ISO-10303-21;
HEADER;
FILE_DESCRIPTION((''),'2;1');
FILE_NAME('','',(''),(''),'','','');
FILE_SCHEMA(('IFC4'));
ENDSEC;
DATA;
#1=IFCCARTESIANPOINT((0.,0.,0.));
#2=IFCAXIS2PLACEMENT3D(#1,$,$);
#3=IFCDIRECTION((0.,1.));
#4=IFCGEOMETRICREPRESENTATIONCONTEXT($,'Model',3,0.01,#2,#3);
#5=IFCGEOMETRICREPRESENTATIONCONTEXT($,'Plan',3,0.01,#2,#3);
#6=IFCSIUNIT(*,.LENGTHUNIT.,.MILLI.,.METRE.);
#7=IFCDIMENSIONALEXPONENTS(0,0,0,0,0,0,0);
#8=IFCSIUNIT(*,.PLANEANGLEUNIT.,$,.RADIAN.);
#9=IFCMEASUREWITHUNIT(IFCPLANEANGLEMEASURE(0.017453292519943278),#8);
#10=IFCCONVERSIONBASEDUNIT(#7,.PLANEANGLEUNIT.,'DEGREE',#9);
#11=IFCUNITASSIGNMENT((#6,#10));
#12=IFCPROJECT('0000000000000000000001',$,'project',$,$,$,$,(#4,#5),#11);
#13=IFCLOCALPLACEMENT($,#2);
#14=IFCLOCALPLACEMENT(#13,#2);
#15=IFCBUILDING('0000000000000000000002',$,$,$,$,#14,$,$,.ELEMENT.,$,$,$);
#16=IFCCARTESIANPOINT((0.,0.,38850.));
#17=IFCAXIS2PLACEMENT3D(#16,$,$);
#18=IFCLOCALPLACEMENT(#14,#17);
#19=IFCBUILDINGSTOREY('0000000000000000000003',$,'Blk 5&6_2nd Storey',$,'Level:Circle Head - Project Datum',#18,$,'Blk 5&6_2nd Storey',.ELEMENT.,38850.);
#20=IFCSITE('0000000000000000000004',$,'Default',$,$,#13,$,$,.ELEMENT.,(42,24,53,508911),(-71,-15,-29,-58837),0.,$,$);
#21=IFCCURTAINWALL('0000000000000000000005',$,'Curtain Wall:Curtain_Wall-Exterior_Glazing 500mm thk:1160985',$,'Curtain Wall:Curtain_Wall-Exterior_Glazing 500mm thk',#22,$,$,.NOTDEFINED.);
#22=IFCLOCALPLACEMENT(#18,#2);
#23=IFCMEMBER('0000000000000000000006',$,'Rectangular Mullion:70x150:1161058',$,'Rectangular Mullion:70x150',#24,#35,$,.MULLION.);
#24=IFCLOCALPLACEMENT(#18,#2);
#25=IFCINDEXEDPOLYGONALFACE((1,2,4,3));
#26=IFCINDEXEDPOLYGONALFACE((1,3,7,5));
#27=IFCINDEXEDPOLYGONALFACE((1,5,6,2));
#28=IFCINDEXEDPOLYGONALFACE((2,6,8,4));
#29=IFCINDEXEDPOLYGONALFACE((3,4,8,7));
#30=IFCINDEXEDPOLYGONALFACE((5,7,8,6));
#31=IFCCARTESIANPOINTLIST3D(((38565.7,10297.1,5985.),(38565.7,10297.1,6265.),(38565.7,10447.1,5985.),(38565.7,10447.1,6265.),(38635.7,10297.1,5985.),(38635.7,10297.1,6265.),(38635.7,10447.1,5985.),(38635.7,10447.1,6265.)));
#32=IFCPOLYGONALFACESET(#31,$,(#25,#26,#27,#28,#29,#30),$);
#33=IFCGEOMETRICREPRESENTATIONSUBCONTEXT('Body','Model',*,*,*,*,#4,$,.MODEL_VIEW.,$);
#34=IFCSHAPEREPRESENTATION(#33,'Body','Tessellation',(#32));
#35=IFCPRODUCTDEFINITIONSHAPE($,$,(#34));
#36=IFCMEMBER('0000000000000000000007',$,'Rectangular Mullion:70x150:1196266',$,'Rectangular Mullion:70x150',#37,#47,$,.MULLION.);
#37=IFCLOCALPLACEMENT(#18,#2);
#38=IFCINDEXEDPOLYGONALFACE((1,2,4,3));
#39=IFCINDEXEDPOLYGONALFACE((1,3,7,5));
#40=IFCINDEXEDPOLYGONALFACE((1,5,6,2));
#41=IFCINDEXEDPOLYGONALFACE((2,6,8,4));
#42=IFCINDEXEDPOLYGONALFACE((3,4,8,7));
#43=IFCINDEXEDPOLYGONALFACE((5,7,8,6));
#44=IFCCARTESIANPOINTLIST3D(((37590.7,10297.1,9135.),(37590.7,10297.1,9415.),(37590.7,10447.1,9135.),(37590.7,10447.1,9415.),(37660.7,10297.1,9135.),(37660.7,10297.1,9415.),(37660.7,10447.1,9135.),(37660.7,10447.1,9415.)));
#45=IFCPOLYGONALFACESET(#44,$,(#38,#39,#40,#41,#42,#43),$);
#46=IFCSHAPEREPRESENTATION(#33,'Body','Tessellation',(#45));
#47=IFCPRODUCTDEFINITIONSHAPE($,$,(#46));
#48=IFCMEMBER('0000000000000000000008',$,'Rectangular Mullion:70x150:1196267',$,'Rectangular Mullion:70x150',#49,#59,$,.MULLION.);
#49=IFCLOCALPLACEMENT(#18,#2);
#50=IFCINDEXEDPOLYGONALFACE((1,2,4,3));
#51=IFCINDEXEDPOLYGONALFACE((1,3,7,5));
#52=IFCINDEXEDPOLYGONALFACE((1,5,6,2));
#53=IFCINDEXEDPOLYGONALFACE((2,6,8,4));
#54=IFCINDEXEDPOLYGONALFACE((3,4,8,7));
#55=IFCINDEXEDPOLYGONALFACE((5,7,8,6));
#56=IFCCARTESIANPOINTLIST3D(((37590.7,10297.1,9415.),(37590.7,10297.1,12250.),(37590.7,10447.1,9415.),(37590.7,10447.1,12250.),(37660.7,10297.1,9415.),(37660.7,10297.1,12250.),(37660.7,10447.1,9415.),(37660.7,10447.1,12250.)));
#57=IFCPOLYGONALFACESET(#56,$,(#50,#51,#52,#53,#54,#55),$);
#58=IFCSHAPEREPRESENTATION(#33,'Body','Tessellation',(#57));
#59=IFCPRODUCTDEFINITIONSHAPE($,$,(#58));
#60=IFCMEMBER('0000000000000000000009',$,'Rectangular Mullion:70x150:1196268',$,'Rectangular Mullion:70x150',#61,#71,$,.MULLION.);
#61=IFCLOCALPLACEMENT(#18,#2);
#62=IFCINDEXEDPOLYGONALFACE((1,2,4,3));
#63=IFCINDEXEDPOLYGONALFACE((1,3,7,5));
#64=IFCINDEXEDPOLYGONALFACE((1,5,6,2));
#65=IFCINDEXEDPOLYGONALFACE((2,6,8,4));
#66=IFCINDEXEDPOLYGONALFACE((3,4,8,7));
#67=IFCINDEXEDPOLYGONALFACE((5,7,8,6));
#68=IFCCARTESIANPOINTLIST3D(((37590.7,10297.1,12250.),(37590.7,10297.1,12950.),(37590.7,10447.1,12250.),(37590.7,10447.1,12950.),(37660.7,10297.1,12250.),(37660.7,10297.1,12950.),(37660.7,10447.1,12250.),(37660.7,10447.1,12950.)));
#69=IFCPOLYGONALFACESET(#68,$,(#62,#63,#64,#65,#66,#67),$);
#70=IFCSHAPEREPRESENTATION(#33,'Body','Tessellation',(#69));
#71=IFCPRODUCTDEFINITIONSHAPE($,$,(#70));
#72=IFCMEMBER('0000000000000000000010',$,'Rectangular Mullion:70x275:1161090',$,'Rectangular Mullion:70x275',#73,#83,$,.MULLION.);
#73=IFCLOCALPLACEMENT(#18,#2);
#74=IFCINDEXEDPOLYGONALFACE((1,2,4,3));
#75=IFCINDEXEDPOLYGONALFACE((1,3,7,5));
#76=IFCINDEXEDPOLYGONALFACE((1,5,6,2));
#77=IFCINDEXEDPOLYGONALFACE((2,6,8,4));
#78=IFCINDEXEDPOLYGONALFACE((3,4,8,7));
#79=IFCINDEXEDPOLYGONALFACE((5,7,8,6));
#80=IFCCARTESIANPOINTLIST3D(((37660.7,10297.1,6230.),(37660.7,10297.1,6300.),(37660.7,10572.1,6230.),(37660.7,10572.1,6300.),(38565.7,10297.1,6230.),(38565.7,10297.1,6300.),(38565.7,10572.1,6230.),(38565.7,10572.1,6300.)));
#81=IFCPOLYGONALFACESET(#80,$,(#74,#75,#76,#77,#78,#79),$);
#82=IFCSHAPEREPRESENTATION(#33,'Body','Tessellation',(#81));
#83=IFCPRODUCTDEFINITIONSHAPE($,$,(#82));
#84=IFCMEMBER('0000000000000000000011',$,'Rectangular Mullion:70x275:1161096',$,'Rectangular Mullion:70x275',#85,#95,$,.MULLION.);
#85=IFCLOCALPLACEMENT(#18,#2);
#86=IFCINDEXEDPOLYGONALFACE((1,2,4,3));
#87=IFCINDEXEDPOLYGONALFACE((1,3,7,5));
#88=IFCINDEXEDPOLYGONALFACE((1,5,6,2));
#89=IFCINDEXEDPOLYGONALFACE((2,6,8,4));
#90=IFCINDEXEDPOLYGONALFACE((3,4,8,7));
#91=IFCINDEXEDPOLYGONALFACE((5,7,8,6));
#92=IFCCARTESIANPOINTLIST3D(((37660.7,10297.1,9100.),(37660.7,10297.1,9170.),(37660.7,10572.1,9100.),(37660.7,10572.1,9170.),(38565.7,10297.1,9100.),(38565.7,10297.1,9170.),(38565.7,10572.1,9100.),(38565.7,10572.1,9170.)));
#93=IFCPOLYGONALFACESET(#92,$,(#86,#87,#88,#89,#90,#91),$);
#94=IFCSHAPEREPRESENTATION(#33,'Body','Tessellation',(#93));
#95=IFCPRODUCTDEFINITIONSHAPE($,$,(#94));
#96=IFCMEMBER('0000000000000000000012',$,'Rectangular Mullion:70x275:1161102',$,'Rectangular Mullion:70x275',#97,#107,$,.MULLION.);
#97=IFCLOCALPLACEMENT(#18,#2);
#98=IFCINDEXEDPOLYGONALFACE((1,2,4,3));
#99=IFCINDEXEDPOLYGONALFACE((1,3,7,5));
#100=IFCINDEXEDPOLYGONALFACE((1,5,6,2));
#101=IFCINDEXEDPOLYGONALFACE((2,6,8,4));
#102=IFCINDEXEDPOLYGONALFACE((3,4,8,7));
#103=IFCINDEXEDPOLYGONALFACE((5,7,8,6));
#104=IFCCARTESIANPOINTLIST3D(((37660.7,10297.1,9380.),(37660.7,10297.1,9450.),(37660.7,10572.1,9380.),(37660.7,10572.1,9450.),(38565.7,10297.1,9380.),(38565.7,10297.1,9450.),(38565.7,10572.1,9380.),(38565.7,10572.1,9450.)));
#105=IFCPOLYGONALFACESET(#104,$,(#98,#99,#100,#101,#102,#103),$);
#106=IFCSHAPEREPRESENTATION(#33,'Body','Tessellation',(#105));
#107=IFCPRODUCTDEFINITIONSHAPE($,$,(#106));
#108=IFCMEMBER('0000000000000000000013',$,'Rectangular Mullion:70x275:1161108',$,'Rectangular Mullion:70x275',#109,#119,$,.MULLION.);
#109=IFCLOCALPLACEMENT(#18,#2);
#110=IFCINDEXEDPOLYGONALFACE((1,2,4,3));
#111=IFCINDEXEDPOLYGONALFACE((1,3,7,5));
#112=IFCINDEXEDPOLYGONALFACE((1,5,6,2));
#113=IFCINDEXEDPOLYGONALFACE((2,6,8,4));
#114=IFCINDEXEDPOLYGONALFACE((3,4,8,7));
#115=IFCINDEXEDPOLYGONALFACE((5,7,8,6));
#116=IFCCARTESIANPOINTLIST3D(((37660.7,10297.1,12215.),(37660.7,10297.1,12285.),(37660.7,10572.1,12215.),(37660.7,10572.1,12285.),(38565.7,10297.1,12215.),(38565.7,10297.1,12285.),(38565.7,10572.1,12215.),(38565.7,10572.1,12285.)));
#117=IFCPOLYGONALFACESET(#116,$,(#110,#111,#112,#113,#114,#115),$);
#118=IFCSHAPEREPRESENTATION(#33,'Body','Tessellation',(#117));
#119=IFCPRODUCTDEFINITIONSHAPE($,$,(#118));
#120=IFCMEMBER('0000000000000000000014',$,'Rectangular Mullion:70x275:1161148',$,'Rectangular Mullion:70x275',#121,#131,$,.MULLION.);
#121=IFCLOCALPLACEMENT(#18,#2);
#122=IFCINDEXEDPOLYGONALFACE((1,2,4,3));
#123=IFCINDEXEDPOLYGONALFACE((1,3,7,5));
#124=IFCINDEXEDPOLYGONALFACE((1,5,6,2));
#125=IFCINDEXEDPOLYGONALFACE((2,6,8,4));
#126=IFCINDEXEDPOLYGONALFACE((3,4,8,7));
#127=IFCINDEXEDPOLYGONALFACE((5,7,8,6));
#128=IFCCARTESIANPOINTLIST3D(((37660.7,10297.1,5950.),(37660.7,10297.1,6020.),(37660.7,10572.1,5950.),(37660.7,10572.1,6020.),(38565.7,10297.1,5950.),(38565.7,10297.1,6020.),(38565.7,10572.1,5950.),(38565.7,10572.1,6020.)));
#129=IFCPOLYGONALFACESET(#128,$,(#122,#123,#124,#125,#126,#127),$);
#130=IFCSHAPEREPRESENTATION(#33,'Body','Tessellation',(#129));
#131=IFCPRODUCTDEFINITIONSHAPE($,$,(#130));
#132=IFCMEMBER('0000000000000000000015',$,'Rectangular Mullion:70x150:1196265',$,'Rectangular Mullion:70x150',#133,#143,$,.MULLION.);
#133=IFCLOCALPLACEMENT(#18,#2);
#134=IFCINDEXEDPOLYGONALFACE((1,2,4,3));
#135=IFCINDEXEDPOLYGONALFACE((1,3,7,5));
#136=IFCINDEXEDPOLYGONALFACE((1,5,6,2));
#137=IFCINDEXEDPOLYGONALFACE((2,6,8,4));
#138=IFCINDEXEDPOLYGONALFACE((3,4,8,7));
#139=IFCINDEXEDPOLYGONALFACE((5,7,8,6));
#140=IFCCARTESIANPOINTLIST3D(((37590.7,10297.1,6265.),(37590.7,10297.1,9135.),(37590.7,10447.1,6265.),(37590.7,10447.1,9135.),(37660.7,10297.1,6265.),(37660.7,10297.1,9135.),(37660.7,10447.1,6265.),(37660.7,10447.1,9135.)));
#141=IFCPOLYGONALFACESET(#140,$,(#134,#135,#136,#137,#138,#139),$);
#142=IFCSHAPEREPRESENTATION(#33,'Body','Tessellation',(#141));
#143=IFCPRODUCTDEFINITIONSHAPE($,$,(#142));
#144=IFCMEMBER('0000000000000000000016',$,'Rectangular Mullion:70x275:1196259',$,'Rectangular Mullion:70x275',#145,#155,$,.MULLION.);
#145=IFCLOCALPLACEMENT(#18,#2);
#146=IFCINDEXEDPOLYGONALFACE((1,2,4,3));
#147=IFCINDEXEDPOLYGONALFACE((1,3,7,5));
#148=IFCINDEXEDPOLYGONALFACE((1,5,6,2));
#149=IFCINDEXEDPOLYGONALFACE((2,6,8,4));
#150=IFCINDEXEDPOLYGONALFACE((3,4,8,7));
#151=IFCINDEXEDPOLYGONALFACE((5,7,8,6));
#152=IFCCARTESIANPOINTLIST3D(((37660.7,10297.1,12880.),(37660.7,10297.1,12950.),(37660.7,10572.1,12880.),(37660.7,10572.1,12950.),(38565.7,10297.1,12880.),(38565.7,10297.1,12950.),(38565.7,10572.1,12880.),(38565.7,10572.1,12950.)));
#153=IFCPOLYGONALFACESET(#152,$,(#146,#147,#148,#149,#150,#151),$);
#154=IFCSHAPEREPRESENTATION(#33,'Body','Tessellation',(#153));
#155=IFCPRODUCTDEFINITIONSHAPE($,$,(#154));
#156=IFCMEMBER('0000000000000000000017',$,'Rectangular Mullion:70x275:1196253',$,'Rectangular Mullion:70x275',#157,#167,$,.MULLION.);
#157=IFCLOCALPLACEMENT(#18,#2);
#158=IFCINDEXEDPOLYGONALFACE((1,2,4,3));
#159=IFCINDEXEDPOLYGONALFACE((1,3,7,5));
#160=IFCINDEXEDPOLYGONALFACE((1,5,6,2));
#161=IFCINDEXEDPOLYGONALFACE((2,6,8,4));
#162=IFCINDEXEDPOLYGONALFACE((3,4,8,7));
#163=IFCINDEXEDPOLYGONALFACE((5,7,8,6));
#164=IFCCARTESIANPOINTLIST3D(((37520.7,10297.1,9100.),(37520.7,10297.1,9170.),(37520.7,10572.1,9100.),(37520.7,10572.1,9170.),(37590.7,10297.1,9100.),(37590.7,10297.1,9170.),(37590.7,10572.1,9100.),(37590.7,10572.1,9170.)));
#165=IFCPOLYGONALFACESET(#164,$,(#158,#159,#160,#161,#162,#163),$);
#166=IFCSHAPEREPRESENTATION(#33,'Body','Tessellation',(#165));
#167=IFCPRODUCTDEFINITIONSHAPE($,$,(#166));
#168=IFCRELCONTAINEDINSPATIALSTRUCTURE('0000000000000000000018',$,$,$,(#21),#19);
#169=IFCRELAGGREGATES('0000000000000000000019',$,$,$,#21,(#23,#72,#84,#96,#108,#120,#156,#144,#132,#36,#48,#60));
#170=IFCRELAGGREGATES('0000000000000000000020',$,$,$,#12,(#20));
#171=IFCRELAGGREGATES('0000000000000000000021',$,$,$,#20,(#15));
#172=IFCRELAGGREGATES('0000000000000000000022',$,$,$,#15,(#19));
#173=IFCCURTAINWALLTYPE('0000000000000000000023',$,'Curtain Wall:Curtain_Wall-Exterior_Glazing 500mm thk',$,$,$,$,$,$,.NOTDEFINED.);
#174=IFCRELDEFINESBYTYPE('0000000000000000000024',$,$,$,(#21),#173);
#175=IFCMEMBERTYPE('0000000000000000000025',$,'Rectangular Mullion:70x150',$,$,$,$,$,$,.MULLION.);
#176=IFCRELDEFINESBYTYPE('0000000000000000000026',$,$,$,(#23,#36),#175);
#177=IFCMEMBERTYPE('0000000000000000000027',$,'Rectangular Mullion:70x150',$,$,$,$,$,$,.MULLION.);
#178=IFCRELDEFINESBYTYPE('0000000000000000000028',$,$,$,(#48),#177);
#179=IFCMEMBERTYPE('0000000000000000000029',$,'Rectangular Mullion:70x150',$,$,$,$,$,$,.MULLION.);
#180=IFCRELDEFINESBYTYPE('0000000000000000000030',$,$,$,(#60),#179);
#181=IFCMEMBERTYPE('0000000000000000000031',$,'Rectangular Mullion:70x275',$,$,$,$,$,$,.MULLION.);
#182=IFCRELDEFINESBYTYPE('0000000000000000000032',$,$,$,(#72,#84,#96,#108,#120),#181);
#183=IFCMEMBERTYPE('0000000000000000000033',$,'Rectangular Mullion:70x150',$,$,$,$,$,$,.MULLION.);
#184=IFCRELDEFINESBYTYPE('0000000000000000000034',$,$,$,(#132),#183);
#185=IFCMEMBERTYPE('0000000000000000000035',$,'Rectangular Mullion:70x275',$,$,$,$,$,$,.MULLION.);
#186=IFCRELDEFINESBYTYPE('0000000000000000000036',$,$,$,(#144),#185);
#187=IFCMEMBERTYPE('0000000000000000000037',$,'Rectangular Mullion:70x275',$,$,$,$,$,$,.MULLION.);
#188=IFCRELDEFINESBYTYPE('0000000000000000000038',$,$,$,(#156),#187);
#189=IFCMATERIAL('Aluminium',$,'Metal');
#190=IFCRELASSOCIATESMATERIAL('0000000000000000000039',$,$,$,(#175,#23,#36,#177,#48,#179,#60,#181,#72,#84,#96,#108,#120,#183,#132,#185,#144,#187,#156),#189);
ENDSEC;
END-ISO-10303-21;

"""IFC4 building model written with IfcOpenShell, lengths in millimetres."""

from ifc_helpers import new_model, entity, si_unit, converted_unit, direction, frame, origin, place, context, subcontext, project, spatial, indexed_curve, outline, extrude, source, transform, mapped, material, type_object, type_shapes, element, aggregate, save


model = new_model("IFC4")

# Units and contexts
model_context = context("Model", 3, precision=0.01, world=origin(), true_north=direction((0.0, 1.0)))
plan_context = context("Plan", 3, precision=0.01, world=origin(), true_north=direction((0.0, 1.0)))
body_context = subcontext(model_context, "Body", "Model", "MODEL_VIEW")
ifc_project = project(units=[si_unit("LENGTHUNIT", "METRE", prefix="MILLI"), converted_unit("PLANEANGLEUNIT", "DEGREE", entity("IfcPlaneAngleMeasure", 0.017453292519943278), si_unit("PLANEANGLEUNIT", "RADIAN"), dimensions=[0, 0, 0, 0, 0, 0, 0])], contexts=[model_context, plan_context])

# Site, building, storey
site_placement = place(None, origin())
site = spatial("IfcSite", under=ifc_project, at=site_placement, Name="Default", CompositionType="ELEMENT", RefLatitude=(42, 24, 53, 508911), RefLongitude=(-71, -15, -29, -58837), RefElevation=0.0)
building_placement = place(site_placement, origin())
building = spatial("IfcBuilding", under=site, at=building_placement, CompositionType="ELEMENT")
storey_placement = place(building_placement, frame((0.0, 0.0, 38850.0)))
storey = spatial("IfcBuildingStorey", under=building, at=storey_placement, Name="Blk 5&6_2nd Storey", ObjectType="Level:Circle Head - Project Datum", LongName="Blk 5&6_2nd Storey", CompositionType="ELEMENT", Elevation=38850.0)

# Curtain wall, members
curtain_wall_type = type_object("IfcCurtainWallType", Name="Curtain Wall:Curtain_Wall-Exterior_Glazing 500mm thk", PredefinedType="NOTDEFINED")
curtain_wall_placement = place(storey_placement, frame((0.0, 0.0, -38850.0)))
curtain_wall = element("IfcCurtainWall", 1, at=curtain_wall_placement, inside=storey, type_object=curtain_wall_type, Name="Curtain Wall:Curtain_Wall-Exterior_Glazing 500mm thk:1160985", ObjectType="Curtain Wall:Curtain_Wall-Exterior_Glazing 500mm thk", PredefinedType="NOTDEFINED")
ifc_material_1 = material(Name="Aluminium", Category="Metal")
member_type_1 = type_object("IfcMemberType", Name="Rectangular Mullion:70x150", PredefinedType="MULLION", material=ifc_material_1)
shared_shape_1 = source(origin(), body_context, "Body", "SweptSolid", [
    extrude(outline(indexed_curve([(-35.0, -75.0), (35.0, -75.0), (35.0, 75.0), (-35.0, 75.0), (-35.0, -75.0)], self_intersect=False)), frame((0.0, -200.0, -280.0), z_axis=(0.0, 0.0, 1.0), x_axis=(-1.0, 0.0, 0.0)), (0.0, 0.0, 1.0), 280.0),
])
type_shapes(member_type_1, [shared_shape_1])
member_1_placement = place(curtain_wall_placement, frame((38600.7, 10572.1, 44835.0), z_axis=(0.0, 0.0, -1.0), x_axis=(-1.0, 0.0, 0.0)))
member_1 = element("IfcMember", 2, at=member_1_placement, type_object=member_type_1, material=ifc_material_1, Name="Rectangular Mullion:70x150:1161058", ObjectType="Rectangular Mullion:70x150", PredefinedType="MULLION", context=body_context, shape_type="MappedRepresentation", body=[
    mapped(shared_shape_1, transform((0.0, 0.0, 0.0), scale=1.0)),
])
member_2_placement = place(curtain_wall_placement, frame((37625.7, 10572.1, 47985.0), z_axis=(0.0, 0.0, -1.0), x_axis=(-1.0, 0.0, 0.0)))
member_2 = element("IfcMember", 3, at=member_2_placement, type_object=member_type_1, material=ifc_material_1, Name="Rectangular Mullion:70x150:1196266", ObjectType="Rectangular Mullion:70x150", PredefinedType="MULLION", context=body_context, shape_type="MappedRepresentation", body=[
    mapped(shared_shape_1, transform((0.0, 0.0, 0.0), scale=1.0)),
])
member_type_2 = type_object("IfcMemberType", Name="Rectangular Mullion:70x150", PredefinedType="MULLION", material=ifc_material_1)
shared_shape_2 = source(origin(), body_context, "Body", "SweptSolid", [
    extrude(outline(indexed_curve([(-35.0, -75.0), (35.0, -75.0), (35.0, 75.0), (-35.0, 75.0), (-35.0, -75.0)], self_intersect=False)), frame((0.0, -200.0, -2835.0), z_axis=(0.0, 0.0, 1.0), x_axis=(-1.0, 0.0, 0.0)), (0.0, 0.0, 1.0), 2835.0),
])
type_shapes(member_type_2, [shared_shape_2])
member_3_placement = place(curtain_wall_placement, frame((37625.7, 10572.1, 48265.0), z_axis=(0.0, 0.0, -1.0), x_axis=(-1.0, 0.0, 0.0)))
member_3 = element("IfcMember", 4, at=member_3_placement, type_object=member_type_2, material=ifc_material_1, Name="Rectangular Mullion:70x150:1196267", ObjectType="Rectangular Mullion:70x150", PredefinedType="MULLION", context=body_context, shape_type="MappedRepresentation", body=[
    mapped(shared_shape_2, transform((0.0, 0.0, 0.0), scale=1.0)),
])
member_type_3 = type_object("IfcMemberType", Name="Rectangular Mullion:70x150", PredefinedType="MULLION", material=ifc_material_1)
shared_shape_3 = source(origin(), body_context, "Body", "SweptSolid", [
    extrude(outline(indexed_curve([(-35.0, -75.0), (35.0, -75.0), (35.0, 75.0), (-35.0, 75.0), (-35.0, -75.0)], self_intersect=False)), frame((0.0, -200.0, -700.0), z_axis=(0.0, 0.0, 1.0), x_axis=(-1.0, 0.0, 0.0)), (0.0, 0.0, 1.0), 700.0),
])
type_shapes(member_type_3, [shared_shape_3])
member_4_placement = place(curtain_wall_placement, frame((37625.7, 10572.1, 51100.0), z_axis=(0.0, 0.0, -1.0), x_axis=(-1.0, 0.0, 0.0)))
member_4 = element("IfcMember", 5, at=member_4_placement, type_object=member_type_3, material=ifc_material_1, Name="Rectangular Mullion:70x150:1196268", ObjectType="Rectangular Mullion:70x150", PredefinedType="MULLION", context=body_context, shape_type="MappedRepresentation", body=[
    mapped(shared_shape_3, transform((0.0, 0.0, 0.0), scale=1.0)),
])
member_type_4 = type_object("IfcMemberType", Name="Rectangular Mullion:70x275", PredefinedType="MULLION", material=ifc_material_1)
shared_shape_4 = source(origin(), body_context, "Body", "SweptSolid", [
    extrude(outline(indexed_curve([(-35.0, -137.5), (35.0, -137.5), (35.0, 137.5), (-35.0, 137.5), (-35.0, -137.5)], self_intersect=False)), frame((0.0, -137.5, -905.0), z_axis=(0.0, 0.0, 1.0), x_axis=(-1.0, 0.0, 0.0)), (0.0, 0.0, 1.0), 905.0),
])
type_shapes(member_type_4, [shared_shape_4])
member_5_placement = place(curtain_wall_placement, frame((37660.7, 10572.1, 45115.0), z_axis=(-1.0, 0.0, 0.0), x_axis=(0.0, 0.0, 1.0)))
member_5 = element("IfcMember", 6, at=member_5_placement, type_object=member_type_4, material=ifc_material_1, Name="Rectangular Mullion:70x275:1161090", ObjectType="Rectangular Mullion:70x275", PredefinedType="MULLION", context=body_context, shape_type="MappedRepresentation", body=[
    mapped(shared_shape_4, transform((0.0, 0.0, 0.0), scale=1.0)),
])
member_6_placement = place(curtain_wall_placement, frame((37660.7, 10572.1, 47985.0), z_axis=(-1.0, 0.0, 0.0), x_axis=(0.0, 0.0, 1.0)))
member_6 = element("IfcMember", 7, at=member_6_placement, type_object=member_type_4, material=ifc_material_1, Name="Rectangular Mullion:70x275:1161096", ObjectType="Rectangular Mullion:70x275", PredefinedType="MULLION", context=body_context, shape_type="MappedRepresentation", body=[
    mapped(shared_shape_4, transform((0.0, 0.0, 0.0), scale=1.0)),
])
member_7_placement = place(curtain_wall_placement, frame((37660.7, 10572.1, 48265.0), z_axis=(-1.0, 0.0, 0.0), x_axis=(0.0, 0.0, 1.0)))
member_7 = element("IfcMember", 8, at=member_7_placement, type_object=member_type_4, material=ifc_material_1, Name="Rectangular Mullion:70x275:1161102", ObjectType="Rectangular Mullion:70x275", PredefinedType="MULLION", context=body_context, shape_type="MappedRepresentation", body=[
    mapped(shared_shape_4, transform((0.0, 0.0, 0.0), scale=1.0)),
])
member_8_placement = place(curtain_wall_placement, frame((37660.7, 10572.1, 51100.0), z_axis=(-1.0, 0.0, 0.0), x_axis=(0.0, 0.0, 1.0)))
member_8 = element("IfcMember", 9, at=member_8_placement, type_object=member_type_4, material=ifc_material_1, Name="Rectangular Mullion:70x275:1161108", ObjectType="Rectangular Mullion:70x275", PredefinedType="MULLION", context=body_context, shape_type="MappedRepresentation", body=[
    mapped(shared_shape_4, transform((0.0, 0.0, 0.0), scale=1.0)),
])
member_9_placement = place(curtain_wall_placement, frame((37660.7, 10572.1, 44835.0), z_axis=(-1.0, 0.0, 0.0), x_axis=(0.0, 0.0, 1.0)))
member_9 = element("IfcMember", 10, at=member_9_placement, type_object=member_type_4, material=ifc_material_1, Name="Rectangular Mullion:70x275:1161148", ObjectType="Rectangular Mullion:70x275", PredefinedType="MULLION", context=body_context, shape_type="MappedRepresentation", body=[
    mapped(shared_shape_4, transform((0.0, 0.0, 0.0), scale=1.0)),
])
member_type_5 = type_object("IfcMemberType", Name="Rectangular Mullion:70x150", PredefinedType="MULLION", material=ifc_material_1)
shared_shape_5 = source(origin(), body_context, "Body", "SweptSolid", [
    extrude(outline(indexed_curve([(-35.0, -75.0), (35.0, -75.0), (35.0, 75.0), (-35.0, 75.0), (-35.0, -75.0)], self_intersect=False)), frame((0.0, -200.0, -2870.0), z_axis=(0.0, 0.0, 1.0), x_axis=(-1.0, 0.0, 0.0)), (0.0, 0.0, 1.0), 2870.0),
])
type_shapes(member_type_5, [shared_shape_5])
member_10_placement = place(curtain_wall_placement, frame((37625.7, 10572.1, 45115.0), z_axis=(0.0, 0.0, -1.0), x_axis=(-1.0, 0.0, 0.0)))
member_10 = element("IfcMember", 11, at=member_10_placement, type_object=member_type_5, material=ifc_material_1, Name="Rectangular Mullion:70x150:1196265", ObjectType="Rectangular Mullion:70x150", PredefinedType="MULLION", context=body_context, shape_type="MappedRepresentation", body=[
    mapped(shared_shape_5, transform((0.0, 0.0, 0.0), scale=1.0)),
])
member_type_6 = type_object("IfcMemberType", Name="Rectangular Mullion:70x275", PredefinedType="MULLION", material=ifc_material_1)
shared_shape_6 = source(origin(), body_context, "Body", "SweptSolid", [
    extrude(outline(indexed_curve([(-35.0, -137.5), (35.0, -137.5), (35.0, 137.5), (-35.0, 137.5), (-35.0, -137.5)], self_intersect=False)), frame((-35.0, -137.5, -905.0), z_axis=(0.0, 0.0, 1.0), x_axis=(-1.0, 0.0, 0.0)), (0.0, 0.0, 1.0), 905.0),
])
type_shapes(member_type_6, [shared_shape_6])
member_11_placement = place(curtain_wall_placement, frame((37660.7, 10572.1, 51800.0), z_axis=(-1.0, 0.0, 0.0), x_axis=(0.0, 0.0, 1.0)))
member_11 = element("IfcMember", 12, at=member_11_placement, type_object=member_type_6, material=ifc_material_1, Name="Rectangular Mullion:70x275:1196259", ObjectType="Rectangular Mullion:70x275", PredefinedType="MULLION", context=body_context, shape_type="MappedRepresentation", body=[
    mapped(shared_shape_6, transform((0.0, 0.0, 0.0), scale=1.0)),
])
member_type_7 = type_object("IfcMemberType", Name="Rectangular Mullion:70x275", PredefinedType="MULLION", material=ifc_material_1)
shared_shape_7 = source(origin(), body_context, "Body", "SweptSolid", [
    extrude(outline(indexed_curve([(-35.0, -137.5), (35.0, -137.5), (35.0, 137.5), (-35.0, 137.5), (-35.0, -137.5)], self_intersect=False)), frame((0.0, -137.5, -70.0), z_axis=(0.0, 0.0, 1.0), x_axis=(-1.0, 0.0, 0.0)), (0.0, 0.0, 1.0), 70.0),
])
type_shapes(member_type_7, [shared_shape_7])
member_12_placement = place(curtain_wall_placement, frame((37520.7, 10572.1, 47985.0), z_axis=(-1.0, 0.0, 0.0), x_axis=(0.0, 0.0, 1.0)))
member_12 = element("IfcMember", 13, at=member_12_placement, type_object=member_type_7, material=ifc_material_1, Name="Rectangular Mullion:70x275:1196253", ObjectType="Rectangular Mullion:70x275", PredefinedType="MULLION", context=body_context, shape_type="MappedRepresentation", body=[
    mapped(shared_shape_7, transform((0.0, 0.0, 0.0), scale=1.0)),
])
aggregate(curtain_wall, [member_1, member_5, member_6, member_7, member_8, member_9, member_12, member_11, member_10, member_2, member_3, member_4])

save(model, "model.ifc")
